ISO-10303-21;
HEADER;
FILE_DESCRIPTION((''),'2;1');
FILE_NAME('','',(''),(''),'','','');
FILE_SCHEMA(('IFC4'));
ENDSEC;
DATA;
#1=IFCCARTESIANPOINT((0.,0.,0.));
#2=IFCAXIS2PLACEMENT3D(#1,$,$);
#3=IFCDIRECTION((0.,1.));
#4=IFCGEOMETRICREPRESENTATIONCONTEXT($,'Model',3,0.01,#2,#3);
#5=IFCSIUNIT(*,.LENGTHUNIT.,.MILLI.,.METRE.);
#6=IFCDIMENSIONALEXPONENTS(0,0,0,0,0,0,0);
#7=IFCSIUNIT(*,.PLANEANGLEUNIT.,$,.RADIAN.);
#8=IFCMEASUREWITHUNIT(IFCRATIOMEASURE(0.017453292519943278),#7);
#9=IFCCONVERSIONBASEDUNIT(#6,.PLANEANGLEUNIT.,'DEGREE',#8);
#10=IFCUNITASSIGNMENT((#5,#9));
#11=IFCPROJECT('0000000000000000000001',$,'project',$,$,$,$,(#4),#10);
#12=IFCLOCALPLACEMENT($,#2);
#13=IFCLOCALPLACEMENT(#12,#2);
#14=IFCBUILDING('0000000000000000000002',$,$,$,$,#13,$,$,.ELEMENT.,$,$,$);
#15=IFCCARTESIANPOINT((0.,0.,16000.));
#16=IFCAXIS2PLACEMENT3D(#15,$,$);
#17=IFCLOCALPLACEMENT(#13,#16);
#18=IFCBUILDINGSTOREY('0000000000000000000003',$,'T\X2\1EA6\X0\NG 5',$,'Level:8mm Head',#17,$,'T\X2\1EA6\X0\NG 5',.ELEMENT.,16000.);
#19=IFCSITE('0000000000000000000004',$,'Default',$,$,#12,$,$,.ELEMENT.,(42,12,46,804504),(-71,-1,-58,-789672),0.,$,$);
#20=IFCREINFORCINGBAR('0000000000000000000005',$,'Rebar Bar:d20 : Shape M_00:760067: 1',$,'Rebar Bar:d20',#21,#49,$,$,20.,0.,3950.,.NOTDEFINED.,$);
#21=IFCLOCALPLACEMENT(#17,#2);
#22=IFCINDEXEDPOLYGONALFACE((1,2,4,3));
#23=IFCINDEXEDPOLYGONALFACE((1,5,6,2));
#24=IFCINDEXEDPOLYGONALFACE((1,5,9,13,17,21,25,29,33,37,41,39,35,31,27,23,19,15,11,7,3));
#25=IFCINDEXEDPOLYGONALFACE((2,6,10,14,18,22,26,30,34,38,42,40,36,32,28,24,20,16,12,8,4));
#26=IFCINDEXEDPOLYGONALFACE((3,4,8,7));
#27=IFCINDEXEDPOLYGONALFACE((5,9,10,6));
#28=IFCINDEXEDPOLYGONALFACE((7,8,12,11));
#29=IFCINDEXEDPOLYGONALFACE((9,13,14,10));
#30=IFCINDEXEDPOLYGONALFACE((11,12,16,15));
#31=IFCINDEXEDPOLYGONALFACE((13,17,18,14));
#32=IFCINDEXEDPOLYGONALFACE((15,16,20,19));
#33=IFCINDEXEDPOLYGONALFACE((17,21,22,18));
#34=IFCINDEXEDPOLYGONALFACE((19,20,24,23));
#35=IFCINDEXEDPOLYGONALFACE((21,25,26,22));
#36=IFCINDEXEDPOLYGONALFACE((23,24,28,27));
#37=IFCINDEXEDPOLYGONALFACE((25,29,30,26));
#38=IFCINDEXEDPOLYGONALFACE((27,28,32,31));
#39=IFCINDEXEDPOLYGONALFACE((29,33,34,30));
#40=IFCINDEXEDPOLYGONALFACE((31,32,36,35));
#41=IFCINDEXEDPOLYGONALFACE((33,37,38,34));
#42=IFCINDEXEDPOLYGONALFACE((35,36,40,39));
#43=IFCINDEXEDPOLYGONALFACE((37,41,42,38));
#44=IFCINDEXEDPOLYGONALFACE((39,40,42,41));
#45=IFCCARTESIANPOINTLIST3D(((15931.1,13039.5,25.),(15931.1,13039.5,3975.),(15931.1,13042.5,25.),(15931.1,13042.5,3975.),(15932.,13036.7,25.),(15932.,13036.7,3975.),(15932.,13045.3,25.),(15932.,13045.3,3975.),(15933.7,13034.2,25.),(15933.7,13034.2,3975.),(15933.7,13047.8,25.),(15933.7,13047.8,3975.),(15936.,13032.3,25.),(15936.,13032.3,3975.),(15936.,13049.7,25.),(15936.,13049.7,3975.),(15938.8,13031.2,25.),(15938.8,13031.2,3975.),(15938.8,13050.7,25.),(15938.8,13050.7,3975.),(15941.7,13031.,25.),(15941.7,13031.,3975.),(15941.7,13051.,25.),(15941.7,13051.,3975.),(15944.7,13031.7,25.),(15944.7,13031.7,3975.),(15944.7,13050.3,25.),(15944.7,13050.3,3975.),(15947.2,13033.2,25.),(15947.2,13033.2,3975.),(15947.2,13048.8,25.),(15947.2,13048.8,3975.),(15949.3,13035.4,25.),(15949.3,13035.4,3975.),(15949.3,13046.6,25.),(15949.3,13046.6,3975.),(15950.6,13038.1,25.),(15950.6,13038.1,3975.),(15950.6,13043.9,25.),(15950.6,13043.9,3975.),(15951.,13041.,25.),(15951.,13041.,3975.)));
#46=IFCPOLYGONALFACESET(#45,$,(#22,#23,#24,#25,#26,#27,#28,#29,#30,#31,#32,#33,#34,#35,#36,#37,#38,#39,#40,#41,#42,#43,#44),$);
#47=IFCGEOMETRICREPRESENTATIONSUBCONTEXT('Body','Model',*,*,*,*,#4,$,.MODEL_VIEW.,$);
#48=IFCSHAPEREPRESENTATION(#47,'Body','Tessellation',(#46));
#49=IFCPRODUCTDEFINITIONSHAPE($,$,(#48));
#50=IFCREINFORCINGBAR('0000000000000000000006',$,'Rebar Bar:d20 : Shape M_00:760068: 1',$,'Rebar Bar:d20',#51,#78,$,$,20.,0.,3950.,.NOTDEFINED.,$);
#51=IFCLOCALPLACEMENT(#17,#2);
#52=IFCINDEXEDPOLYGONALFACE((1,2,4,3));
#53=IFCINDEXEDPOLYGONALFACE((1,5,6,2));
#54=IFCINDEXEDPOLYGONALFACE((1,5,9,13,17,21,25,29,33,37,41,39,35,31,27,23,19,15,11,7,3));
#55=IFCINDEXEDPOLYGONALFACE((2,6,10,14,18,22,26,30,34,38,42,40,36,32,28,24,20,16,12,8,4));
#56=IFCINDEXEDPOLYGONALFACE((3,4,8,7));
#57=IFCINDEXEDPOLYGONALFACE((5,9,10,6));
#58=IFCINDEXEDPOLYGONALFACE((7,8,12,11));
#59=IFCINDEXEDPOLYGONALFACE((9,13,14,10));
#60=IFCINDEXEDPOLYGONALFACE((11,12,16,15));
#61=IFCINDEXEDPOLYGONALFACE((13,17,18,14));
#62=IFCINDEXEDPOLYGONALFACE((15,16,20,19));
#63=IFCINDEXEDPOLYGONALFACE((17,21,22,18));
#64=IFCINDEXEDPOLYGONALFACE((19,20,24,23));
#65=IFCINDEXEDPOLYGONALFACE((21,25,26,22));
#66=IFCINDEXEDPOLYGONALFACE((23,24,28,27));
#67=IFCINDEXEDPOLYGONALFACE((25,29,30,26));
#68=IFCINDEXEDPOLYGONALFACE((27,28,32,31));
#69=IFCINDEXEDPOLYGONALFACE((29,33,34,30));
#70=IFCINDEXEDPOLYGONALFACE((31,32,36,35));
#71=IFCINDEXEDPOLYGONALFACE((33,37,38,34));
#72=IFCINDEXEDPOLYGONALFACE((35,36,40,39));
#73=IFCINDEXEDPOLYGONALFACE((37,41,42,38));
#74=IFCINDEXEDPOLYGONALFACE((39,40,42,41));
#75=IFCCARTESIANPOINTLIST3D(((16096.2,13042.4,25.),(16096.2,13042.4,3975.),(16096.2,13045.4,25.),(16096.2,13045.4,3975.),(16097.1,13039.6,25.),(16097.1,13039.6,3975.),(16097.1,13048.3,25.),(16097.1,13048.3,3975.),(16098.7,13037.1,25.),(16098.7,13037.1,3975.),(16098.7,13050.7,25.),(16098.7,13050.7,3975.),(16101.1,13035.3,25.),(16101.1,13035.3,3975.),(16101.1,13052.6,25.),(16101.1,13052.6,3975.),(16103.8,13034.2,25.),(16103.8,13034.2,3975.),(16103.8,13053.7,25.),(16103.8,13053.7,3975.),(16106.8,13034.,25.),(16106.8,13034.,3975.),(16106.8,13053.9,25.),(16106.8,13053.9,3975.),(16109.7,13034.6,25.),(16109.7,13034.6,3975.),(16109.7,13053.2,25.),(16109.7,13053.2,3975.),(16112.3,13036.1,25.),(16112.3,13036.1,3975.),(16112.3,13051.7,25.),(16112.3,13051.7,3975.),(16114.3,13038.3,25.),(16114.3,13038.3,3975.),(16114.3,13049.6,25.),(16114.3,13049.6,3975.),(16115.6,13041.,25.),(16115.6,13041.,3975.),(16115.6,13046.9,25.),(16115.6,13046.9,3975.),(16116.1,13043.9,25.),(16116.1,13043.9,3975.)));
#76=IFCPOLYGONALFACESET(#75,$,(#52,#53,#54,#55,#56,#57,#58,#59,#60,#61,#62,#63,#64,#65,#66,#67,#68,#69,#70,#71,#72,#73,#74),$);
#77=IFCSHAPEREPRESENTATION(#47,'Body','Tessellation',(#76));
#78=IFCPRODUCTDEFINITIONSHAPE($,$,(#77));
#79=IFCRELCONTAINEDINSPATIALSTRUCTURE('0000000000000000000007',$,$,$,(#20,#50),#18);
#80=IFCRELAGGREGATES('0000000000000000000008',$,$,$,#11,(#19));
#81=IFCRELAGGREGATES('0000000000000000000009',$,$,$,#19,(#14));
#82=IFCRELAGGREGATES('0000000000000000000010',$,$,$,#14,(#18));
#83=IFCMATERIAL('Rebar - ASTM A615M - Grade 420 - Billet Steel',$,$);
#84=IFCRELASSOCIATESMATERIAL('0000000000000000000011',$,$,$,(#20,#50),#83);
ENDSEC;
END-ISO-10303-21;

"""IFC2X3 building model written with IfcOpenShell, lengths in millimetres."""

from ifc_helpers import new_model, entity, si_unit, converted_unit, direction, frame, origin, place, context, subcontext, project, spatial, material, element, save


model = new_model("IFC2X3")

# Units and contexts
model_context = context("Model", 3, precision=0.01, world=origin(), true_north=direction((0.0, 1.0)))
body_context = subcontext(model_context, "Body", "Model", "MODEL_VIEW")
ifc_project = project(units=[si_unit("LENGTHUNIT", "METRE", prefix="MILLI"), converted_unit("PLANEANGLEUNIT", "DEGREE", entity("IfcRatioMeasure", 0.017453292519943278), si_unit("PLANEANGLEUNIT", "RADIAN"), dimensions=[0, 0, 0, 0, 0, 0, 0])], contexts=[model_context])

# Site, building, storey
site_placement = place(None, origin())
site = spatial("IfcSite", under=ifc_project, at=site_placement, Name="Default", CompositionType="ELEMENT", RefLatitude=(42, 12, 46, 804504), RefLongitude=(-71, -1, -58, -789672), RefElevation=0.0)
building_placement = place(site_placement, origin())
building = spatial("IfcBuilding", under=site, at=building_placement, CompositionType="ELEMENT")
storey_placement = place(building_placement, frame((0.0, 0.0, 16000.0)))
storey = spatial("IfcBuildingStorey", under=building, at=storey_placement, Name="TẦNG 5", ObjectType="Level:8mm Head", LongName="TẦNG 5", CompositionType="ELEMENT", Elevation=16000.0)

# Reinforcing bars
ifc_material = material(Name="Rebar - ASTM A615M - Grade 420 - Billet Steel")
reinforcing_bar_1_placement = place(storey_placement, origin())
element("IfcReinforcingBar", 1, at=reinforcing_bar_1_placement, inside=storey, material=ifc_material, Name="Rebar Bar:d20 : Shape M_00:760067: 1", ObjectType="Rebar Bar:d20", BarLength=3950.0, BarRole="NOTDEFINED", CrossSectionArea=0.0, NominalDiameter=20.0, context=body_context, shape_type="AdvancedSweptSolid", body=[
    entity("IfcSweptDiskSolid", entity("IfcCompositeCurve", [entity("IfcCompositeCurveSegment", "CONTINUOUS", True, entity("IfcPolyline", [entity("IfcCartesianPoint", [15941.0, 13041.0, 25.0]), entity("IfcCartesianPoint", [15941.0, 13041.0, 3975.0])]))], False), 10.0, None, 0.0, 1.0),
])
reinforcing_bar_2_placement = place(storey_placement, origin())
element("IfcReinforcingBar", 2, at=reinforcing_bar_2_placement, inside=storey, material=ifc_material, Name="Rebar Bar:d20 : Shape M_00:760068: 1", ObjectType="Rebar Bar:d20", BarLength=3950.0, BarRole="NOTDEFINED", CrossSectionArea=0.0, NominalDiameter=20.0, context=body_context, shape_type="AdvancedSweptSolid", body=[
    entity("IfcSweptDiskSolid", entity("IfcCompositeCurve", [entity("IfcCompositeCurveSegment", "CONTINUOUS", True, entity("IfcPolyline", [entity("IfcCartesianPoint", [16106.1, 13043.9, 25.0]), entity("IfcCartesianPoint", [16106.1, 13043.9, 3975.0])]))], False), 10.0, None, 0.0, 1.0),
])

save(model, "model.ifc")
